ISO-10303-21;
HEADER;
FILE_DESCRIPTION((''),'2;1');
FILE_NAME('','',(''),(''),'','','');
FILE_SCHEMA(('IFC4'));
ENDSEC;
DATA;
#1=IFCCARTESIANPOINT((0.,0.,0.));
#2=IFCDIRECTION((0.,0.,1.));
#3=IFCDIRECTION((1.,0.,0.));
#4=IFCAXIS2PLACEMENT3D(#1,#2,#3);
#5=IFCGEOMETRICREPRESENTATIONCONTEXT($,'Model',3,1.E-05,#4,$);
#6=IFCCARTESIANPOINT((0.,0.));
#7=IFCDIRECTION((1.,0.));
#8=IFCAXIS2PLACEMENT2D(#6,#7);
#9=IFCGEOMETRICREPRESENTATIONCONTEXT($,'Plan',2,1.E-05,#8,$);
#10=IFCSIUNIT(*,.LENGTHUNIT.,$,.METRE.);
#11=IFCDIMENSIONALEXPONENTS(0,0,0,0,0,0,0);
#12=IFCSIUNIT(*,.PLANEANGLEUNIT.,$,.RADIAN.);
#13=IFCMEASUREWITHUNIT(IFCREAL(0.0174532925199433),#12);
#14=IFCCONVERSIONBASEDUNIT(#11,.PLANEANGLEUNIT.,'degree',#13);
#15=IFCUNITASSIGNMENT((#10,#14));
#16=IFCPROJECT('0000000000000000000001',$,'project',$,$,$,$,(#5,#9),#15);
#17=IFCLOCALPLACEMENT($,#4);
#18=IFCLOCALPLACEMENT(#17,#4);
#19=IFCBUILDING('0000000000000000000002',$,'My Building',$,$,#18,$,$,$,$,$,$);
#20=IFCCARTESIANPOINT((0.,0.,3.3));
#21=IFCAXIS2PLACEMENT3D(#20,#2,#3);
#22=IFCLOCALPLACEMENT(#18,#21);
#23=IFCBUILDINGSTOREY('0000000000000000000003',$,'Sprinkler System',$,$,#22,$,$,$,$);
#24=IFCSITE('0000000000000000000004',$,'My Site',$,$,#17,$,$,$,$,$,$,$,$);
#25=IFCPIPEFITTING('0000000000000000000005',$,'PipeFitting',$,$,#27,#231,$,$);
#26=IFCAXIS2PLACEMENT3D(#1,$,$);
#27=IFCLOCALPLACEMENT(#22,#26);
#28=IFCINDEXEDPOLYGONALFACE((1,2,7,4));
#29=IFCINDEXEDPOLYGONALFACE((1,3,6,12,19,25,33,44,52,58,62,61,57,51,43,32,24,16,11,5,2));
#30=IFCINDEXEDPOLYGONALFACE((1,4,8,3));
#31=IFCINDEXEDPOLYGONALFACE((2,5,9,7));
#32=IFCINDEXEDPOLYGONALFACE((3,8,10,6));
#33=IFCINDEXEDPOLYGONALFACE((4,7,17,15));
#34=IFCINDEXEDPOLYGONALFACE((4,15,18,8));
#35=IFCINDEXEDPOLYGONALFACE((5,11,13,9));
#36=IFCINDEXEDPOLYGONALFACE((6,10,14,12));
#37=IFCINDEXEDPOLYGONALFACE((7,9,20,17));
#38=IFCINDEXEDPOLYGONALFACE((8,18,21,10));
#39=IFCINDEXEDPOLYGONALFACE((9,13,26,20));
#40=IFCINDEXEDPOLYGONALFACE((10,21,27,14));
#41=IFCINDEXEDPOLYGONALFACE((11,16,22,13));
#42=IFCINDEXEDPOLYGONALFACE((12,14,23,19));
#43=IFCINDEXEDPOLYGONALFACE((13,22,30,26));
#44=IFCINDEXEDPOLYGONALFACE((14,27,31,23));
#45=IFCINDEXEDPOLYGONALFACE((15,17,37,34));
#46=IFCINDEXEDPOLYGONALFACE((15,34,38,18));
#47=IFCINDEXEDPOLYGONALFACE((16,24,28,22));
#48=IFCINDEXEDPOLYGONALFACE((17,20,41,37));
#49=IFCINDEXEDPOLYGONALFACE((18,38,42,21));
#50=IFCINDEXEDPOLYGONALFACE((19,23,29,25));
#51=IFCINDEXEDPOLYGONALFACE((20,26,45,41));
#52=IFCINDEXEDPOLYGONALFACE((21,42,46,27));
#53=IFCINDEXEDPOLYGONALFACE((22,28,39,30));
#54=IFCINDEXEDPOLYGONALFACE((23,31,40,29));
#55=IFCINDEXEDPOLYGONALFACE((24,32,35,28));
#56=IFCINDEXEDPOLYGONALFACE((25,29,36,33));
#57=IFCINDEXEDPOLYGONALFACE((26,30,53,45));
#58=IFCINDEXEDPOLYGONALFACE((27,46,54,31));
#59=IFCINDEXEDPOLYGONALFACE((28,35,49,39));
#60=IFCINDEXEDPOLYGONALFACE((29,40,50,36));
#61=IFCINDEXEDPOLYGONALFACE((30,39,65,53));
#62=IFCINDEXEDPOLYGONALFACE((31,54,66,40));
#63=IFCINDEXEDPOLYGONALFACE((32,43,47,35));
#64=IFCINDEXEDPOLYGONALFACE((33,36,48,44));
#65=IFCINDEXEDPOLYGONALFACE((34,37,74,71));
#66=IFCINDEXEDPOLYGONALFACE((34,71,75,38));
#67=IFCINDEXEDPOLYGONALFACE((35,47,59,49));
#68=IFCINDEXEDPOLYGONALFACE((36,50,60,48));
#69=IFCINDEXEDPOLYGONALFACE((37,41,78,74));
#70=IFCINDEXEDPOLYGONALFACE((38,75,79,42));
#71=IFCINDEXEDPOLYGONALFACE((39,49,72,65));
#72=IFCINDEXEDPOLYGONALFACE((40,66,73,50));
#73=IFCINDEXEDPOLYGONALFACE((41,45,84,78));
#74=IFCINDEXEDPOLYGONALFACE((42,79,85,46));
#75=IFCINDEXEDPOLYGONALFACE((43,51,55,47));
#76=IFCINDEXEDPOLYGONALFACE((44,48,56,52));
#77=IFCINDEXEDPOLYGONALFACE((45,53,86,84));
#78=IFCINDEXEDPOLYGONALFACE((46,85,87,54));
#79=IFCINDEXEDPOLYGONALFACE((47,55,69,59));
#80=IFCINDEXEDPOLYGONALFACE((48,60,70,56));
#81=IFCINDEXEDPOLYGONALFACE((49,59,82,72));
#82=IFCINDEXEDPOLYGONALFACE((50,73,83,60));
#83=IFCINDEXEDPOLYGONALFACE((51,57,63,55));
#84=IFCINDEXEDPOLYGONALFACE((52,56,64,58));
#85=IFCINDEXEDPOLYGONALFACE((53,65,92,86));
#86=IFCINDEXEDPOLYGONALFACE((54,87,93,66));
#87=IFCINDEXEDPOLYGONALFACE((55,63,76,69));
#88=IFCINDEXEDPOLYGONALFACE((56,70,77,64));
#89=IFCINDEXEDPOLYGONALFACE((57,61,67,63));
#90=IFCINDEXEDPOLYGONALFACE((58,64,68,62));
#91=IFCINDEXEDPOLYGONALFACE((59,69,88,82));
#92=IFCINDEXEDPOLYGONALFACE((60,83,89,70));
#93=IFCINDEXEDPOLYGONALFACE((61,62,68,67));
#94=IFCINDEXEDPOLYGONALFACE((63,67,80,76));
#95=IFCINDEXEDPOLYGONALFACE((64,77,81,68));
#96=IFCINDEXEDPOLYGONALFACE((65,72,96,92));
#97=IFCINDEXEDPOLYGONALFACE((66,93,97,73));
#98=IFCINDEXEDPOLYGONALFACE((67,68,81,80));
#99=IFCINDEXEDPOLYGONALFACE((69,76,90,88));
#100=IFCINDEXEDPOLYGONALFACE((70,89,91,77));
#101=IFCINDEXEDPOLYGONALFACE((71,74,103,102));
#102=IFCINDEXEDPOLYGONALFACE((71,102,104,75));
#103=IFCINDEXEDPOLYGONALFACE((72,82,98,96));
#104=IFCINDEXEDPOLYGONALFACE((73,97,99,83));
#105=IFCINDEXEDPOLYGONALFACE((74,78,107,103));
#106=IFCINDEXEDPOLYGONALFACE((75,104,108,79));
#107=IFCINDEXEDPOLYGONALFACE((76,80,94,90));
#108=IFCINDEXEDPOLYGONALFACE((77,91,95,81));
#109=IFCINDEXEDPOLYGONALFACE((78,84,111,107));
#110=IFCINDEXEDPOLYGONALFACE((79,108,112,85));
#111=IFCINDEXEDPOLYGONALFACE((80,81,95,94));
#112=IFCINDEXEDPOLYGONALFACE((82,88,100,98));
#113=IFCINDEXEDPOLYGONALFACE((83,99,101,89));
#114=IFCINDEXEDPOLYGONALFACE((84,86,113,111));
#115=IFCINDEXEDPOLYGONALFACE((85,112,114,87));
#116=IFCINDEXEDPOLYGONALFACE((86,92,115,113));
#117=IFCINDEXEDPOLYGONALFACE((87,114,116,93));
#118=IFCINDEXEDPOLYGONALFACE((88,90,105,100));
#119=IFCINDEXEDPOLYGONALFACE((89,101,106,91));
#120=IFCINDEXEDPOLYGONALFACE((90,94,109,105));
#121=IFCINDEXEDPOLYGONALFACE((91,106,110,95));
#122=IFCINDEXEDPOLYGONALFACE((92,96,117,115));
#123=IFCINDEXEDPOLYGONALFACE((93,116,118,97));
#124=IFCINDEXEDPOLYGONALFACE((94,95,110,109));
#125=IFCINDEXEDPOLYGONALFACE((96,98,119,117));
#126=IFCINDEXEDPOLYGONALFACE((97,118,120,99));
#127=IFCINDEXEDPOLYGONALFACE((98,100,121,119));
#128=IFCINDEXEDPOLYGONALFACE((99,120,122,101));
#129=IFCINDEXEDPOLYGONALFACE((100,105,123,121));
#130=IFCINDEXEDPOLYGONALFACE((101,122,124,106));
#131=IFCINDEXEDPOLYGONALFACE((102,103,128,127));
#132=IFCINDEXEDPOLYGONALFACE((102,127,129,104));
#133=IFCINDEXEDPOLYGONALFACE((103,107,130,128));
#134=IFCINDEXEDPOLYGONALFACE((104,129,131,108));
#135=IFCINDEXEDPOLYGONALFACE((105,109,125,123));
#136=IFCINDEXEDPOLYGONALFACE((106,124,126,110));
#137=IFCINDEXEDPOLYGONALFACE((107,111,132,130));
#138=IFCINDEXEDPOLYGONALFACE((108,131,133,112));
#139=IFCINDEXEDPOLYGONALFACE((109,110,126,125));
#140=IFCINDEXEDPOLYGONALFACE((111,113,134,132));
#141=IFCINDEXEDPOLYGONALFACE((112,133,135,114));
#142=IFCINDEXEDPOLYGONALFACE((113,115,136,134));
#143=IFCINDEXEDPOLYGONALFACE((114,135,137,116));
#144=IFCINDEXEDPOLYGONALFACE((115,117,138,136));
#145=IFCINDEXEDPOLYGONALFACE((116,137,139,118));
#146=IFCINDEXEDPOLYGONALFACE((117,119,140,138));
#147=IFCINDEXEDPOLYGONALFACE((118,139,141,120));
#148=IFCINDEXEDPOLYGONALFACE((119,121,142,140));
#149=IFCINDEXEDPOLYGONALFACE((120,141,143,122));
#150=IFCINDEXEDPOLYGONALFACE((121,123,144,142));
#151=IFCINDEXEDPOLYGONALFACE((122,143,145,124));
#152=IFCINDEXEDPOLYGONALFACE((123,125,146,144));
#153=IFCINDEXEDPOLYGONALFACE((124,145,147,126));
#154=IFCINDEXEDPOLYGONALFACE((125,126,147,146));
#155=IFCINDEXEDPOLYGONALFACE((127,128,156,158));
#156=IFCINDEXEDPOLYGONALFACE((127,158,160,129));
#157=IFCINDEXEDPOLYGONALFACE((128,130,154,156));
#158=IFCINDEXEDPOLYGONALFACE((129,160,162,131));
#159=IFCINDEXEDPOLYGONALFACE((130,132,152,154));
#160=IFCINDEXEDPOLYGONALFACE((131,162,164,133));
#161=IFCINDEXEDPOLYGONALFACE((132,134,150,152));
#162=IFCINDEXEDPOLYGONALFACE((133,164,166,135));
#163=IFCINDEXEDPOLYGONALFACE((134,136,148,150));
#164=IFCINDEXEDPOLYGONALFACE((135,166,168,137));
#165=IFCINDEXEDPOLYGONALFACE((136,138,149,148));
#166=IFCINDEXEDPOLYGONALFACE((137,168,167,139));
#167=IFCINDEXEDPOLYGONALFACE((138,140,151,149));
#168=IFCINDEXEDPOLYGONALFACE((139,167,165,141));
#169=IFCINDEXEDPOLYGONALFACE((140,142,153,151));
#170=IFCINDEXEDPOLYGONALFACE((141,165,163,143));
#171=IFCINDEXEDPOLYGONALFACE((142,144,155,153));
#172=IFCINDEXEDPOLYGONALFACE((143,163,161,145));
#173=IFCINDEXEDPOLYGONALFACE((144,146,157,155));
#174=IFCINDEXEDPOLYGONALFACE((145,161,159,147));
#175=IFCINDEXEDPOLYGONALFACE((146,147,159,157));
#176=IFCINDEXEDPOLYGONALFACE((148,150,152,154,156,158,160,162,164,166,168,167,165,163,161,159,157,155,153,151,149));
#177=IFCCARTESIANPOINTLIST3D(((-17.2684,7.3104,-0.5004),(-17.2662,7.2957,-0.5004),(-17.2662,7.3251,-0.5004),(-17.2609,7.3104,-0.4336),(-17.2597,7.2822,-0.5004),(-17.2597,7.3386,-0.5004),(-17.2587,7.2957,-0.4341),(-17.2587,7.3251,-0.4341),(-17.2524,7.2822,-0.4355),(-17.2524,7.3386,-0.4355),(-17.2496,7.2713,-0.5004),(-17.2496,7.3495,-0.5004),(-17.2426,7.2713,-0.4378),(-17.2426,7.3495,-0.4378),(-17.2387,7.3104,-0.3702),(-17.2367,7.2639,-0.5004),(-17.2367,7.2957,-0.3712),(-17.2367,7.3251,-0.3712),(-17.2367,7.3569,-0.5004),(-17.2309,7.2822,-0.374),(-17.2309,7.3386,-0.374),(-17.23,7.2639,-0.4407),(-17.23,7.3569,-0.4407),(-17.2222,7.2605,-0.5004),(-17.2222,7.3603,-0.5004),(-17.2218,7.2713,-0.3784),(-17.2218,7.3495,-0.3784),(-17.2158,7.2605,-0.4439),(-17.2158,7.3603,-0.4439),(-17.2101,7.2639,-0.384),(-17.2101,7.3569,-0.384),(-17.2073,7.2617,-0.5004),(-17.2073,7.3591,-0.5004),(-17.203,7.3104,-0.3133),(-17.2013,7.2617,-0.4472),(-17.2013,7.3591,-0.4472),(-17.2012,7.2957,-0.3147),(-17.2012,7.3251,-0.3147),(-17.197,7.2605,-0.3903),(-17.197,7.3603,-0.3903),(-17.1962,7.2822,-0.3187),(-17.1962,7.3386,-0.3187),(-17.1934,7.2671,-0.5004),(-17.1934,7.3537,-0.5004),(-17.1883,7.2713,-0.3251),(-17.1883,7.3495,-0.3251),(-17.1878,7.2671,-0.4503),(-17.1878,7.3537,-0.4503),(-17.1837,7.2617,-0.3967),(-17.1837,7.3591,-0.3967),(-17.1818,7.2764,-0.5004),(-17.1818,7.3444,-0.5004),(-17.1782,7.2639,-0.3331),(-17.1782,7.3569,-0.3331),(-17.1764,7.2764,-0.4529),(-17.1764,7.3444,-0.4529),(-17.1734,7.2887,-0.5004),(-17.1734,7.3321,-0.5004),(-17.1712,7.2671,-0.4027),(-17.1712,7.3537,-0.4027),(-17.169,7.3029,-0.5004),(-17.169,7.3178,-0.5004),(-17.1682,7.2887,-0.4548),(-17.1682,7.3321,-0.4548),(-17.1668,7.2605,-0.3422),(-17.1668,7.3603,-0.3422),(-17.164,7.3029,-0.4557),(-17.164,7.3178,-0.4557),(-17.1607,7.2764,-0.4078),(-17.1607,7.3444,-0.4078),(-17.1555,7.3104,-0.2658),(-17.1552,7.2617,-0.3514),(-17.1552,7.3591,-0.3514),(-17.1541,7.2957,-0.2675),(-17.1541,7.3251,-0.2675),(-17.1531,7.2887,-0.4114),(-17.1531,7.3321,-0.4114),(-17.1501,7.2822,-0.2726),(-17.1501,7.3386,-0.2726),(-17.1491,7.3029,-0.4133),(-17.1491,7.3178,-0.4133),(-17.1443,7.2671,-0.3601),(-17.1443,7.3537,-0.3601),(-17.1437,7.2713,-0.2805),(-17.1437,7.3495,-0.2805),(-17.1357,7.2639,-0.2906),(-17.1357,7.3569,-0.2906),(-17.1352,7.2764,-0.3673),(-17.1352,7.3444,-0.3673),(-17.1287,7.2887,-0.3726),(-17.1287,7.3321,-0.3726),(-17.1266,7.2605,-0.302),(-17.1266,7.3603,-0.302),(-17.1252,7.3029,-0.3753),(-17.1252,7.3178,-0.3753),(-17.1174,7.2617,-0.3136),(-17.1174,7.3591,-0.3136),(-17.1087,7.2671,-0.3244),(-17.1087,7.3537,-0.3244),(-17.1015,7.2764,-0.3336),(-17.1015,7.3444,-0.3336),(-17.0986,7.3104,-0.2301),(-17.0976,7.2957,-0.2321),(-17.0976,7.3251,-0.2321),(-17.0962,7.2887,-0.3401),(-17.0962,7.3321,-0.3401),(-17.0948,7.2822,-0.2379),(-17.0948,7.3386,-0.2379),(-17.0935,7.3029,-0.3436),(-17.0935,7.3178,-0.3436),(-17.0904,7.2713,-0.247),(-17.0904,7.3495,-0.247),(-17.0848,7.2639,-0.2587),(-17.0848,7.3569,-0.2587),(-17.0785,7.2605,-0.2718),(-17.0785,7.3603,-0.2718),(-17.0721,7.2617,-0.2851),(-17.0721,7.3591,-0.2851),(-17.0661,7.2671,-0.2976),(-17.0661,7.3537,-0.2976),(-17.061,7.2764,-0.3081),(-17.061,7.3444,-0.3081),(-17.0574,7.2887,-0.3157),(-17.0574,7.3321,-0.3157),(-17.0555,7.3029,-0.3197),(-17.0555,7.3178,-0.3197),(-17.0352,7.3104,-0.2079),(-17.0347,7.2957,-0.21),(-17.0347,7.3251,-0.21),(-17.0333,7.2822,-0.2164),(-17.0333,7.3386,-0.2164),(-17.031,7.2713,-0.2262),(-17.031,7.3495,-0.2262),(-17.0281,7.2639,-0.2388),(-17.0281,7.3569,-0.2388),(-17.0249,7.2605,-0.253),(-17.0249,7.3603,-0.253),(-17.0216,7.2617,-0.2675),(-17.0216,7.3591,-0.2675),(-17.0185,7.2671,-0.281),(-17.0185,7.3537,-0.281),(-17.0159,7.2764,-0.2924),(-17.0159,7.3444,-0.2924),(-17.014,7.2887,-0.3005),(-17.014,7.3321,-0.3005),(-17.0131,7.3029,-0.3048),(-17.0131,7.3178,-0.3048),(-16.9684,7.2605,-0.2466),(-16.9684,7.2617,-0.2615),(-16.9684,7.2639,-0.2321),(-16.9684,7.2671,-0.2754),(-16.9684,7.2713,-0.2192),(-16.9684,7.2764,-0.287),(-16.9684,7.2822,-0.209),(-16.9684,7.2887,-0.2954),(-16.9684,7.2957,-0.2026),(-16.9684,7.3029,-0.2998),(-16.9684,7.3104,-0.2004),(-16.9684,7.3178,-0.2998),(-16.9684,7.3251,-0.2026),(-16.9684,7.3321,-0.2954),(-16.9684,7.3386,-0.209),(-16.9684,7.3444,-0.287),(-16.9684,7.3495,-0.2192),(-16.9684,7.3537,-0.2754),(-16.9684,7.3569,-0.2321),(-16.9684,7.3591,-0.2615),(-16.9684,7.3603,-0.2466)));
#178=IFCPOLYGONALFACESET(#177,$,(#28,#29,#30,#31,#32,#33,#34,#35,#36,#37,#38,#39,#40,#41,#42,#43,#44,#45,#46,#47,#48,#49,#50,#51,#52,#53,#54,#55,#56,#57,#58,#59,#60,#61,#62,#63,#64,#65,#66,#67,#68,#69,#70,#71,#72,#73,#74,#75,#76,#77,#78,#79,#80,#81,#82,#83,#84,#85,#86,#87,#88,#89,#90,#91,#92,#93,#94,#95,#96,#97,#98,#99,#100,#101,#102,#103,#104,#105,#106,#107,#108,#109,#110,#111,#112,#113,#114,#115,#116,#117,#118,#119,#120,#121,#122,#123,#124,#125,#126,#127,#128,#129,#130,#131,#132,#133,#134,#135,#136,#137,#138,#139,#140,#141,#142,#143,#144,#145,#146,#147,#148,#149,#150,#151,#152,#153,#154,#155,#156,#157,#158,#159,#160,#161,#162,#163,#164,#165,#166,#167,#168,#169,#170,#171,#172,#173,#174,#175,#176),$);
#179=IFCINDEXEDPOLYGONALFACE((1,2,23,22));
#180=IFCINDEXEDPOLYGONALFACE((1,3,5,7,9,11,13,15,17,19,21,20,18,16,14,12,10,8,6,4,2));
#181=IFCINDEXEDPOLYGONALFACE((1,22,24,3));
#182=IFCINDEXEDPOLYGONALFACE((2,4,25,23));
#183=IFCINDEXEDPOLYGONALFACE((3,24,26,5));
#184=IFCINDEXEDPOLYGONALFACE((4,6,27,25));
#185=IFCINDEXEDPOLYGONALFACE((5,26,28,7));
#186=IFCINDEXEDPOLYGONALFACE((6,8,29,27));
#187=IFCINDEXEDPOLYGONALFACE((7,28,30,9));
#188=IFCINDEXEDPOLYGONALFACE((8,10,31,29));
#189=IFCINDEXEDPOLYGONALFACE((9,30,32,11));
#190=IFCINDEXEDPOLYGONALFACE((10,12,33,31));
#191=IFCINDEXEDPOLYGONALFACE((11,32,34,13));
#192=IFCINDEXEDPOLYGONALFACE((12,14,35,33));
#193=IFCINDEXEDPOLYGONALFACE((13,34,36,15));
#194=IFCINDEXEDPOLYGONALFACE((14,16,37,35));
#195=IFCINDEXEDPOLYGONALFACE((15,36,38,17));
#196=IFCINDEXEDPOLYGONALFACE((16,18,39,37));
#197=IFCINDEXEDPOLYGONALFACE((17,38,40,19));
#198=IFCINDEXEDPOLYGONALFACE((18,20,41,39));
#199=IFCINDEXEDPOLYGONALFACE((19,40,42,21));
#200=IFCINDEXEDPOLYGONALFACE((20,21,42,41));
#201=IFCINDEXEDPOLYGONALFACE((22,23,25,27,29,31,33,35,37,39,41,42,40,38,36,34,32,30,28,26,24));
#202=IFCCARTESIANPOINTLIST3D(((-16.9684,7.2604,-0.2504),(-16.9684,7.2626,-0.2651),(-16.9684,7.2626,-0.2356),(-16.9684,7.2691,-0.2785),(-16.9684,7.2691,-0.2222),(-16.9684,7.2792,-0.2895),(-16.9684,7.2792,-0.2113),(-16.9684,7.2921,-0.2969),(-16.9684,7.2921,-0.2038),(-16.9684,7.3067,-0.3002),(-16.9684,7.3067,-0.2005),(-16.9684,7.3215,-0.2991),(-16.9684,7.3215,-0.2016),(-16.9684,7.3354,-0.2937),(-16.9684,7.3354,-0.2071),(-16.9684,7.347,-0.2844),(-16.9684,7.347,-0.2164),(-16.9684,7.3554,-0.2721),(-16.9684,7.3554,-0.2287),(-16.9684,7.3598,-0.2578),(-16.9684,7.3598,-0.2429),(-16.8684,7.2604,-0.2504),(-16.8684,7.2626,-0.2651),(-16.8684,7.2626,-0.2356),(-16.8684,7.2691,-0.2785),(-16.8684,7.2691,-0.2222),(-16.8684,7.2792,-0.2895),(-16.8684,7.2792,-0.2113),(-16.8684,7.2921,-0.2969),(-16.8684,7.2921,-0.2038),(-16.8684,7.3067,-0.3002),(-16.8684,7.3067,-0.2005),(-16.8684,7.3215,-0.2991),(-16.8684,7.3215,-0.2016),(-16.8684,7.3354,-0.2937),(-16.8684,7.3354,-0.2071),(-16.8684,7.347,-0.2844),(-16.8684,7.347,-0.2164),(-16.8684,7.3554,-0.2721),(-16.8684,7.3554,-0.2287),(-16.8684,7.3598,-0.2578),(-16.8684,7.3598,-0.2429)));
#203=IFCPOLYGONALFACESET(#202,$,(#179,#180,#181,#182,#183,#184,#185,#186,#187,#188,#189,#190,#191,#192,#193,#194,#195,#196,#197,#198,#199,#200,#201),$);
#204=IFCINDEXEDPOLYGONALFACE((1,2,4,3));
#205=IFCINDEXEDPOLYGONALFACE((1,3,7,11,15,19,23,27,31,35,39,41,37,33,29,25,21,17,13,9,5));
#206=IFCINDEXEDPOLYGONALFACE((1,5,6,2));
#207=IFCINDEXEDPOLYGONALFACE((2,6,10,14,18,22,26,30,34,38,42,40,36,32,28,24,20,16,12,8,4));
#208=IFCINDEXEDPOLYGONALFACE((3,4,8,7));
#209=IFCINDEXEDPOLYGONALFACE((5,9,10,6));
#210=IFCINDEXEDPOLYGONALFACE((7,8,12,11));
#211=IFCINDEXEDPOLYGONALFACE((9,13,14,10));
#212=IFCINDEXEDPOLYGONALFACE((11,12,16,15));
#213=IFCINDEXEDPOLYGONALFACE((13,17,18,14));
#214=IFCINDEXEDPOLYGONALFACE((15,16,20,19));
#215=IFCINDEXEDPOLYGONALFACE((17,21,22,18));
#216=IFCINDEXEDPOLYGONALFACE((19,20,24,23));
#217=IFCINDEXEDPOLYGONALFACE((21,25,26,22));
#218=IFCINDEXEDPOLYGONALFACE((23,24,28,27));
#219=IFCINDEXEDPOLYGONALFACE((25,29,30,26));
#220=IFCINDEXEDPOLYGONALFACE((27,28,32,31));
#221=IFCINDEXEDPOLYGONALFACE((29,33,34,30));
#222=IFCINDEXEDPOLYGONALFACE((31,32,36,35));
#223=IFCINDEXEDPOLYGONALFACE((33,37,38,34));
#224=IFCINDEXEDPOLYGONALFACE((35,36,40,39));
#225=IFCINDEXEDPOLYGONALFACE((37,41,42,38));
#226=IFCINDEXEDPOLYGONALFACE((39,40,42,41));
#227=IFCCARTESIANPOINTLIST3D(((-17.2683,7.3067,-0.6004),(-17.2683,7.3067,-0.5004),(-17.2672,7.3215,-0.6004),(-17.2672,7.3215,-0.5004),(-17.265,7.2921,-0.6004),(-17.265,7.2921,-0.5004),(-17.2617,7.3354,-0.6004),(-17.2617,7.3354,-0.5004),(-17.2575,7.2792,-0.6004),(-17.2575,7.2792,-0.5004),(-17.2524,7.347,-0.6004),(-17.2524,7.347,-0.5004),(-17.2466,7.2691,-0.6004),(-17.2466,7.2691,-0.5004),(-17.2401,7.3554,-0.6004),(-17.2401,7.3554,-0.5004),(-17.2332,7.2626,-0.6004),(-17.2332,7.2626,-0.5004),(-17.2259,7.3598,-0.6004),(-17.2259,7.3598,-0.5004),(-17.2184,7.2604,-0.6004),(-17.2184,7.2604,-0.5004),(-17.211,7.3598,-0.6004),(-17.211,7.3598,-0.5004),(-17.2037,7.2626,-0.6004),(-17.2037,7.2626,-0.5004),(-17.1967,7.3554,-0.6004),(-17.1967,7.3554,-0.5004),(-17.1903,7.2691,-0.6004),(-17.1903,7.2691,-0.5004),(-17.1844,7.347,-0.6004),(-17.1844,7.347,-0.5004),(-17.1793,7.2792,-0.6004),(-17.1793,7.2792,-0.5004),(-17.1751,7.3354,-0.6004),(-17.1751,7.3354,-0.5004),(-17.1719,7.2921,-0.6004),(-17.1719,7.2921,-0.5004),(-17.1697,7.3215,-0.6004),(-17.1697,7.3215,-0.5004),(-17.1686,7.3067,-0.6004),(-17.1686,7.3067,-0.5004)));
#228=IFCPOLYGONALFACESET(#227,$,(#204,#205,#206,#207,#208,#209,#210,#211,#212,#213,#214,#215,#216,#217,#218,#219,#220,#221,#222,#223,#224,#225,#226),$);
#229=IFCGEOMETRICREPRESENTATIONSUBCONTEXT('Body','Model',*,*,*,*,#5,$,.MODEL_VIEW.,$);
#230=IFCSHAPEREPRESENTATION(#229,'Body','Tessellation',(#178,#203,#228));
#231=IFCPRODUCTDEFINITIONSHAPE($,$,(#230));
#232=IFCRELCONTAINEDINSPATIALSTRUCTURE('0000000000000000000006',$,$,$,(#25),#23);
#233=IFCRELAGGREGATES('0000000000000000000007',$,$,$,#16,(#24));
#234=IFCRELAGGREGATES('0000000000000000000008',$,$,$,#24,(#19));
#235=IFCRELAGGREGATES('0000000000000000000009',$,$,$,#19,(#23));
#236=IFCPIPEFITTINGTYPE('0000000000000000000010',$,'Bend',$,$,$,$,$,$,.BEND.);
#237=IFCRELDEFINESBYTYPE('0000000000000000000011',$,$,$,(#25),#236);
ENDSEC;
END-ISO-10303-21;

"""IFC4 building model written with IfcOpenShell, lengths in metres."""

from ifc_helpers import new_model, entity, si_unit, converted_unit, frame, origin_with_axes, origin_2d_with_axis, place, context, subcontext, project, spatial, circle, extrude, source, transform, mapped, type_object, type_shapes, element, save


model = new_model("IFC4")

# Units and contexts
model_context = context("Model", 3, precision=1e-05, world=origin_with_axes())
plan_context = context("Plan", 2, precision=1e-05, world=origin_2d_with_axis())
body_context = subcontext(model_context, "Body", "Model", "MODEL_VIEW")
ifc_project = project(units=[si_unit("LENGTHUNIT", "METRE"), converted_unit("PLANEANGLEUNIT", "degree", entity("IfcReal", 0.0174532925199433), si_unit("PLANEANGLEUNIT", "RADIAN"), dimensions=[0, 0, 0, 0, 0, 0, 0])], contexts=[model_context, plan_context])

# Site, building, storey
site_placement = place(None, origin_with_axes())
site = spatial("IfcSite", under=ifc_project, at=site_placement, Name="My Site")
building_placement = place(site_placement, origin_with_axes())
building = spatial("IfcBuilding", under=site, at=building_placement, Name="My Building")
storey_placement = place(building_placement, frame((0.0, 0.0, 3.3), z_axis=(0.0, 0.0, 1.0), x_axis=(1.0, 0.0, 0.0)))
storey = spatial("IfcBuildingStorey", under=building, at=storey_placement, Name="Sprinkler System")

# Pipe fitting
pipe_fitting_type_1 = type_object("IfcPipeFittingType", Name="Bend", PredefinedType="BEND")
shared_shape_1 = source(origin_with_axes(), body_context, "Body", "SolidModel", [
    entity("IfcSweptDiskSolid", entity("IfcIndexedPolyCurve", entity("IfcCartesianPointList3D", [[0.0, 0.0, -0.1], [0.0, 0.0732, -0.2768], [0.0, 0.25, -0.35]]), [entity("IfcArcIndex", [1, 2, 3])]), 0.05),
    extrude(circle(Radius=0.05), origin_with_axes(), (0.0, 0.0, -1.0), 0.1),
    extrude(circle(Radius=0.05), frame((0.0, 0.25, -0.35), z_axis=(0.0, 1.0, 0.0), x_axis=(1.0, 0.0, 0.0)), (0.0, 0.0, 1.0), 0.1),
])
type_shapes(pipe_fitting_type_1, [shared_shape_1])
for number, where, z_axis, x_axis, name in (
    (1, (-16.8684, 7.3104, -0.2504), (1.0, 0.0, 0.0), (0.0, -1.0, 0.0), "PipeFitting"),
):
    element("IfcPipeFitting", number, at=place(storey_placement, frame(where, z_axis=z_axis, x_axis=x_axis)), inside=storey, type_object=pipe_fitting_type_1, Name=name, context=body_context, shape_type="MappedRepresentation", body=[
        mapped(shared_shape_1, transform((0.0, 0.0, 0.0), x_axis=(1.0, 0.0, 0.0), y_axis=(0.0, 1.0, 0.0), z_axis=(0.0, 0.0, 1.0), scale=1.0)),
    ])

save(model, "model.ifc")
